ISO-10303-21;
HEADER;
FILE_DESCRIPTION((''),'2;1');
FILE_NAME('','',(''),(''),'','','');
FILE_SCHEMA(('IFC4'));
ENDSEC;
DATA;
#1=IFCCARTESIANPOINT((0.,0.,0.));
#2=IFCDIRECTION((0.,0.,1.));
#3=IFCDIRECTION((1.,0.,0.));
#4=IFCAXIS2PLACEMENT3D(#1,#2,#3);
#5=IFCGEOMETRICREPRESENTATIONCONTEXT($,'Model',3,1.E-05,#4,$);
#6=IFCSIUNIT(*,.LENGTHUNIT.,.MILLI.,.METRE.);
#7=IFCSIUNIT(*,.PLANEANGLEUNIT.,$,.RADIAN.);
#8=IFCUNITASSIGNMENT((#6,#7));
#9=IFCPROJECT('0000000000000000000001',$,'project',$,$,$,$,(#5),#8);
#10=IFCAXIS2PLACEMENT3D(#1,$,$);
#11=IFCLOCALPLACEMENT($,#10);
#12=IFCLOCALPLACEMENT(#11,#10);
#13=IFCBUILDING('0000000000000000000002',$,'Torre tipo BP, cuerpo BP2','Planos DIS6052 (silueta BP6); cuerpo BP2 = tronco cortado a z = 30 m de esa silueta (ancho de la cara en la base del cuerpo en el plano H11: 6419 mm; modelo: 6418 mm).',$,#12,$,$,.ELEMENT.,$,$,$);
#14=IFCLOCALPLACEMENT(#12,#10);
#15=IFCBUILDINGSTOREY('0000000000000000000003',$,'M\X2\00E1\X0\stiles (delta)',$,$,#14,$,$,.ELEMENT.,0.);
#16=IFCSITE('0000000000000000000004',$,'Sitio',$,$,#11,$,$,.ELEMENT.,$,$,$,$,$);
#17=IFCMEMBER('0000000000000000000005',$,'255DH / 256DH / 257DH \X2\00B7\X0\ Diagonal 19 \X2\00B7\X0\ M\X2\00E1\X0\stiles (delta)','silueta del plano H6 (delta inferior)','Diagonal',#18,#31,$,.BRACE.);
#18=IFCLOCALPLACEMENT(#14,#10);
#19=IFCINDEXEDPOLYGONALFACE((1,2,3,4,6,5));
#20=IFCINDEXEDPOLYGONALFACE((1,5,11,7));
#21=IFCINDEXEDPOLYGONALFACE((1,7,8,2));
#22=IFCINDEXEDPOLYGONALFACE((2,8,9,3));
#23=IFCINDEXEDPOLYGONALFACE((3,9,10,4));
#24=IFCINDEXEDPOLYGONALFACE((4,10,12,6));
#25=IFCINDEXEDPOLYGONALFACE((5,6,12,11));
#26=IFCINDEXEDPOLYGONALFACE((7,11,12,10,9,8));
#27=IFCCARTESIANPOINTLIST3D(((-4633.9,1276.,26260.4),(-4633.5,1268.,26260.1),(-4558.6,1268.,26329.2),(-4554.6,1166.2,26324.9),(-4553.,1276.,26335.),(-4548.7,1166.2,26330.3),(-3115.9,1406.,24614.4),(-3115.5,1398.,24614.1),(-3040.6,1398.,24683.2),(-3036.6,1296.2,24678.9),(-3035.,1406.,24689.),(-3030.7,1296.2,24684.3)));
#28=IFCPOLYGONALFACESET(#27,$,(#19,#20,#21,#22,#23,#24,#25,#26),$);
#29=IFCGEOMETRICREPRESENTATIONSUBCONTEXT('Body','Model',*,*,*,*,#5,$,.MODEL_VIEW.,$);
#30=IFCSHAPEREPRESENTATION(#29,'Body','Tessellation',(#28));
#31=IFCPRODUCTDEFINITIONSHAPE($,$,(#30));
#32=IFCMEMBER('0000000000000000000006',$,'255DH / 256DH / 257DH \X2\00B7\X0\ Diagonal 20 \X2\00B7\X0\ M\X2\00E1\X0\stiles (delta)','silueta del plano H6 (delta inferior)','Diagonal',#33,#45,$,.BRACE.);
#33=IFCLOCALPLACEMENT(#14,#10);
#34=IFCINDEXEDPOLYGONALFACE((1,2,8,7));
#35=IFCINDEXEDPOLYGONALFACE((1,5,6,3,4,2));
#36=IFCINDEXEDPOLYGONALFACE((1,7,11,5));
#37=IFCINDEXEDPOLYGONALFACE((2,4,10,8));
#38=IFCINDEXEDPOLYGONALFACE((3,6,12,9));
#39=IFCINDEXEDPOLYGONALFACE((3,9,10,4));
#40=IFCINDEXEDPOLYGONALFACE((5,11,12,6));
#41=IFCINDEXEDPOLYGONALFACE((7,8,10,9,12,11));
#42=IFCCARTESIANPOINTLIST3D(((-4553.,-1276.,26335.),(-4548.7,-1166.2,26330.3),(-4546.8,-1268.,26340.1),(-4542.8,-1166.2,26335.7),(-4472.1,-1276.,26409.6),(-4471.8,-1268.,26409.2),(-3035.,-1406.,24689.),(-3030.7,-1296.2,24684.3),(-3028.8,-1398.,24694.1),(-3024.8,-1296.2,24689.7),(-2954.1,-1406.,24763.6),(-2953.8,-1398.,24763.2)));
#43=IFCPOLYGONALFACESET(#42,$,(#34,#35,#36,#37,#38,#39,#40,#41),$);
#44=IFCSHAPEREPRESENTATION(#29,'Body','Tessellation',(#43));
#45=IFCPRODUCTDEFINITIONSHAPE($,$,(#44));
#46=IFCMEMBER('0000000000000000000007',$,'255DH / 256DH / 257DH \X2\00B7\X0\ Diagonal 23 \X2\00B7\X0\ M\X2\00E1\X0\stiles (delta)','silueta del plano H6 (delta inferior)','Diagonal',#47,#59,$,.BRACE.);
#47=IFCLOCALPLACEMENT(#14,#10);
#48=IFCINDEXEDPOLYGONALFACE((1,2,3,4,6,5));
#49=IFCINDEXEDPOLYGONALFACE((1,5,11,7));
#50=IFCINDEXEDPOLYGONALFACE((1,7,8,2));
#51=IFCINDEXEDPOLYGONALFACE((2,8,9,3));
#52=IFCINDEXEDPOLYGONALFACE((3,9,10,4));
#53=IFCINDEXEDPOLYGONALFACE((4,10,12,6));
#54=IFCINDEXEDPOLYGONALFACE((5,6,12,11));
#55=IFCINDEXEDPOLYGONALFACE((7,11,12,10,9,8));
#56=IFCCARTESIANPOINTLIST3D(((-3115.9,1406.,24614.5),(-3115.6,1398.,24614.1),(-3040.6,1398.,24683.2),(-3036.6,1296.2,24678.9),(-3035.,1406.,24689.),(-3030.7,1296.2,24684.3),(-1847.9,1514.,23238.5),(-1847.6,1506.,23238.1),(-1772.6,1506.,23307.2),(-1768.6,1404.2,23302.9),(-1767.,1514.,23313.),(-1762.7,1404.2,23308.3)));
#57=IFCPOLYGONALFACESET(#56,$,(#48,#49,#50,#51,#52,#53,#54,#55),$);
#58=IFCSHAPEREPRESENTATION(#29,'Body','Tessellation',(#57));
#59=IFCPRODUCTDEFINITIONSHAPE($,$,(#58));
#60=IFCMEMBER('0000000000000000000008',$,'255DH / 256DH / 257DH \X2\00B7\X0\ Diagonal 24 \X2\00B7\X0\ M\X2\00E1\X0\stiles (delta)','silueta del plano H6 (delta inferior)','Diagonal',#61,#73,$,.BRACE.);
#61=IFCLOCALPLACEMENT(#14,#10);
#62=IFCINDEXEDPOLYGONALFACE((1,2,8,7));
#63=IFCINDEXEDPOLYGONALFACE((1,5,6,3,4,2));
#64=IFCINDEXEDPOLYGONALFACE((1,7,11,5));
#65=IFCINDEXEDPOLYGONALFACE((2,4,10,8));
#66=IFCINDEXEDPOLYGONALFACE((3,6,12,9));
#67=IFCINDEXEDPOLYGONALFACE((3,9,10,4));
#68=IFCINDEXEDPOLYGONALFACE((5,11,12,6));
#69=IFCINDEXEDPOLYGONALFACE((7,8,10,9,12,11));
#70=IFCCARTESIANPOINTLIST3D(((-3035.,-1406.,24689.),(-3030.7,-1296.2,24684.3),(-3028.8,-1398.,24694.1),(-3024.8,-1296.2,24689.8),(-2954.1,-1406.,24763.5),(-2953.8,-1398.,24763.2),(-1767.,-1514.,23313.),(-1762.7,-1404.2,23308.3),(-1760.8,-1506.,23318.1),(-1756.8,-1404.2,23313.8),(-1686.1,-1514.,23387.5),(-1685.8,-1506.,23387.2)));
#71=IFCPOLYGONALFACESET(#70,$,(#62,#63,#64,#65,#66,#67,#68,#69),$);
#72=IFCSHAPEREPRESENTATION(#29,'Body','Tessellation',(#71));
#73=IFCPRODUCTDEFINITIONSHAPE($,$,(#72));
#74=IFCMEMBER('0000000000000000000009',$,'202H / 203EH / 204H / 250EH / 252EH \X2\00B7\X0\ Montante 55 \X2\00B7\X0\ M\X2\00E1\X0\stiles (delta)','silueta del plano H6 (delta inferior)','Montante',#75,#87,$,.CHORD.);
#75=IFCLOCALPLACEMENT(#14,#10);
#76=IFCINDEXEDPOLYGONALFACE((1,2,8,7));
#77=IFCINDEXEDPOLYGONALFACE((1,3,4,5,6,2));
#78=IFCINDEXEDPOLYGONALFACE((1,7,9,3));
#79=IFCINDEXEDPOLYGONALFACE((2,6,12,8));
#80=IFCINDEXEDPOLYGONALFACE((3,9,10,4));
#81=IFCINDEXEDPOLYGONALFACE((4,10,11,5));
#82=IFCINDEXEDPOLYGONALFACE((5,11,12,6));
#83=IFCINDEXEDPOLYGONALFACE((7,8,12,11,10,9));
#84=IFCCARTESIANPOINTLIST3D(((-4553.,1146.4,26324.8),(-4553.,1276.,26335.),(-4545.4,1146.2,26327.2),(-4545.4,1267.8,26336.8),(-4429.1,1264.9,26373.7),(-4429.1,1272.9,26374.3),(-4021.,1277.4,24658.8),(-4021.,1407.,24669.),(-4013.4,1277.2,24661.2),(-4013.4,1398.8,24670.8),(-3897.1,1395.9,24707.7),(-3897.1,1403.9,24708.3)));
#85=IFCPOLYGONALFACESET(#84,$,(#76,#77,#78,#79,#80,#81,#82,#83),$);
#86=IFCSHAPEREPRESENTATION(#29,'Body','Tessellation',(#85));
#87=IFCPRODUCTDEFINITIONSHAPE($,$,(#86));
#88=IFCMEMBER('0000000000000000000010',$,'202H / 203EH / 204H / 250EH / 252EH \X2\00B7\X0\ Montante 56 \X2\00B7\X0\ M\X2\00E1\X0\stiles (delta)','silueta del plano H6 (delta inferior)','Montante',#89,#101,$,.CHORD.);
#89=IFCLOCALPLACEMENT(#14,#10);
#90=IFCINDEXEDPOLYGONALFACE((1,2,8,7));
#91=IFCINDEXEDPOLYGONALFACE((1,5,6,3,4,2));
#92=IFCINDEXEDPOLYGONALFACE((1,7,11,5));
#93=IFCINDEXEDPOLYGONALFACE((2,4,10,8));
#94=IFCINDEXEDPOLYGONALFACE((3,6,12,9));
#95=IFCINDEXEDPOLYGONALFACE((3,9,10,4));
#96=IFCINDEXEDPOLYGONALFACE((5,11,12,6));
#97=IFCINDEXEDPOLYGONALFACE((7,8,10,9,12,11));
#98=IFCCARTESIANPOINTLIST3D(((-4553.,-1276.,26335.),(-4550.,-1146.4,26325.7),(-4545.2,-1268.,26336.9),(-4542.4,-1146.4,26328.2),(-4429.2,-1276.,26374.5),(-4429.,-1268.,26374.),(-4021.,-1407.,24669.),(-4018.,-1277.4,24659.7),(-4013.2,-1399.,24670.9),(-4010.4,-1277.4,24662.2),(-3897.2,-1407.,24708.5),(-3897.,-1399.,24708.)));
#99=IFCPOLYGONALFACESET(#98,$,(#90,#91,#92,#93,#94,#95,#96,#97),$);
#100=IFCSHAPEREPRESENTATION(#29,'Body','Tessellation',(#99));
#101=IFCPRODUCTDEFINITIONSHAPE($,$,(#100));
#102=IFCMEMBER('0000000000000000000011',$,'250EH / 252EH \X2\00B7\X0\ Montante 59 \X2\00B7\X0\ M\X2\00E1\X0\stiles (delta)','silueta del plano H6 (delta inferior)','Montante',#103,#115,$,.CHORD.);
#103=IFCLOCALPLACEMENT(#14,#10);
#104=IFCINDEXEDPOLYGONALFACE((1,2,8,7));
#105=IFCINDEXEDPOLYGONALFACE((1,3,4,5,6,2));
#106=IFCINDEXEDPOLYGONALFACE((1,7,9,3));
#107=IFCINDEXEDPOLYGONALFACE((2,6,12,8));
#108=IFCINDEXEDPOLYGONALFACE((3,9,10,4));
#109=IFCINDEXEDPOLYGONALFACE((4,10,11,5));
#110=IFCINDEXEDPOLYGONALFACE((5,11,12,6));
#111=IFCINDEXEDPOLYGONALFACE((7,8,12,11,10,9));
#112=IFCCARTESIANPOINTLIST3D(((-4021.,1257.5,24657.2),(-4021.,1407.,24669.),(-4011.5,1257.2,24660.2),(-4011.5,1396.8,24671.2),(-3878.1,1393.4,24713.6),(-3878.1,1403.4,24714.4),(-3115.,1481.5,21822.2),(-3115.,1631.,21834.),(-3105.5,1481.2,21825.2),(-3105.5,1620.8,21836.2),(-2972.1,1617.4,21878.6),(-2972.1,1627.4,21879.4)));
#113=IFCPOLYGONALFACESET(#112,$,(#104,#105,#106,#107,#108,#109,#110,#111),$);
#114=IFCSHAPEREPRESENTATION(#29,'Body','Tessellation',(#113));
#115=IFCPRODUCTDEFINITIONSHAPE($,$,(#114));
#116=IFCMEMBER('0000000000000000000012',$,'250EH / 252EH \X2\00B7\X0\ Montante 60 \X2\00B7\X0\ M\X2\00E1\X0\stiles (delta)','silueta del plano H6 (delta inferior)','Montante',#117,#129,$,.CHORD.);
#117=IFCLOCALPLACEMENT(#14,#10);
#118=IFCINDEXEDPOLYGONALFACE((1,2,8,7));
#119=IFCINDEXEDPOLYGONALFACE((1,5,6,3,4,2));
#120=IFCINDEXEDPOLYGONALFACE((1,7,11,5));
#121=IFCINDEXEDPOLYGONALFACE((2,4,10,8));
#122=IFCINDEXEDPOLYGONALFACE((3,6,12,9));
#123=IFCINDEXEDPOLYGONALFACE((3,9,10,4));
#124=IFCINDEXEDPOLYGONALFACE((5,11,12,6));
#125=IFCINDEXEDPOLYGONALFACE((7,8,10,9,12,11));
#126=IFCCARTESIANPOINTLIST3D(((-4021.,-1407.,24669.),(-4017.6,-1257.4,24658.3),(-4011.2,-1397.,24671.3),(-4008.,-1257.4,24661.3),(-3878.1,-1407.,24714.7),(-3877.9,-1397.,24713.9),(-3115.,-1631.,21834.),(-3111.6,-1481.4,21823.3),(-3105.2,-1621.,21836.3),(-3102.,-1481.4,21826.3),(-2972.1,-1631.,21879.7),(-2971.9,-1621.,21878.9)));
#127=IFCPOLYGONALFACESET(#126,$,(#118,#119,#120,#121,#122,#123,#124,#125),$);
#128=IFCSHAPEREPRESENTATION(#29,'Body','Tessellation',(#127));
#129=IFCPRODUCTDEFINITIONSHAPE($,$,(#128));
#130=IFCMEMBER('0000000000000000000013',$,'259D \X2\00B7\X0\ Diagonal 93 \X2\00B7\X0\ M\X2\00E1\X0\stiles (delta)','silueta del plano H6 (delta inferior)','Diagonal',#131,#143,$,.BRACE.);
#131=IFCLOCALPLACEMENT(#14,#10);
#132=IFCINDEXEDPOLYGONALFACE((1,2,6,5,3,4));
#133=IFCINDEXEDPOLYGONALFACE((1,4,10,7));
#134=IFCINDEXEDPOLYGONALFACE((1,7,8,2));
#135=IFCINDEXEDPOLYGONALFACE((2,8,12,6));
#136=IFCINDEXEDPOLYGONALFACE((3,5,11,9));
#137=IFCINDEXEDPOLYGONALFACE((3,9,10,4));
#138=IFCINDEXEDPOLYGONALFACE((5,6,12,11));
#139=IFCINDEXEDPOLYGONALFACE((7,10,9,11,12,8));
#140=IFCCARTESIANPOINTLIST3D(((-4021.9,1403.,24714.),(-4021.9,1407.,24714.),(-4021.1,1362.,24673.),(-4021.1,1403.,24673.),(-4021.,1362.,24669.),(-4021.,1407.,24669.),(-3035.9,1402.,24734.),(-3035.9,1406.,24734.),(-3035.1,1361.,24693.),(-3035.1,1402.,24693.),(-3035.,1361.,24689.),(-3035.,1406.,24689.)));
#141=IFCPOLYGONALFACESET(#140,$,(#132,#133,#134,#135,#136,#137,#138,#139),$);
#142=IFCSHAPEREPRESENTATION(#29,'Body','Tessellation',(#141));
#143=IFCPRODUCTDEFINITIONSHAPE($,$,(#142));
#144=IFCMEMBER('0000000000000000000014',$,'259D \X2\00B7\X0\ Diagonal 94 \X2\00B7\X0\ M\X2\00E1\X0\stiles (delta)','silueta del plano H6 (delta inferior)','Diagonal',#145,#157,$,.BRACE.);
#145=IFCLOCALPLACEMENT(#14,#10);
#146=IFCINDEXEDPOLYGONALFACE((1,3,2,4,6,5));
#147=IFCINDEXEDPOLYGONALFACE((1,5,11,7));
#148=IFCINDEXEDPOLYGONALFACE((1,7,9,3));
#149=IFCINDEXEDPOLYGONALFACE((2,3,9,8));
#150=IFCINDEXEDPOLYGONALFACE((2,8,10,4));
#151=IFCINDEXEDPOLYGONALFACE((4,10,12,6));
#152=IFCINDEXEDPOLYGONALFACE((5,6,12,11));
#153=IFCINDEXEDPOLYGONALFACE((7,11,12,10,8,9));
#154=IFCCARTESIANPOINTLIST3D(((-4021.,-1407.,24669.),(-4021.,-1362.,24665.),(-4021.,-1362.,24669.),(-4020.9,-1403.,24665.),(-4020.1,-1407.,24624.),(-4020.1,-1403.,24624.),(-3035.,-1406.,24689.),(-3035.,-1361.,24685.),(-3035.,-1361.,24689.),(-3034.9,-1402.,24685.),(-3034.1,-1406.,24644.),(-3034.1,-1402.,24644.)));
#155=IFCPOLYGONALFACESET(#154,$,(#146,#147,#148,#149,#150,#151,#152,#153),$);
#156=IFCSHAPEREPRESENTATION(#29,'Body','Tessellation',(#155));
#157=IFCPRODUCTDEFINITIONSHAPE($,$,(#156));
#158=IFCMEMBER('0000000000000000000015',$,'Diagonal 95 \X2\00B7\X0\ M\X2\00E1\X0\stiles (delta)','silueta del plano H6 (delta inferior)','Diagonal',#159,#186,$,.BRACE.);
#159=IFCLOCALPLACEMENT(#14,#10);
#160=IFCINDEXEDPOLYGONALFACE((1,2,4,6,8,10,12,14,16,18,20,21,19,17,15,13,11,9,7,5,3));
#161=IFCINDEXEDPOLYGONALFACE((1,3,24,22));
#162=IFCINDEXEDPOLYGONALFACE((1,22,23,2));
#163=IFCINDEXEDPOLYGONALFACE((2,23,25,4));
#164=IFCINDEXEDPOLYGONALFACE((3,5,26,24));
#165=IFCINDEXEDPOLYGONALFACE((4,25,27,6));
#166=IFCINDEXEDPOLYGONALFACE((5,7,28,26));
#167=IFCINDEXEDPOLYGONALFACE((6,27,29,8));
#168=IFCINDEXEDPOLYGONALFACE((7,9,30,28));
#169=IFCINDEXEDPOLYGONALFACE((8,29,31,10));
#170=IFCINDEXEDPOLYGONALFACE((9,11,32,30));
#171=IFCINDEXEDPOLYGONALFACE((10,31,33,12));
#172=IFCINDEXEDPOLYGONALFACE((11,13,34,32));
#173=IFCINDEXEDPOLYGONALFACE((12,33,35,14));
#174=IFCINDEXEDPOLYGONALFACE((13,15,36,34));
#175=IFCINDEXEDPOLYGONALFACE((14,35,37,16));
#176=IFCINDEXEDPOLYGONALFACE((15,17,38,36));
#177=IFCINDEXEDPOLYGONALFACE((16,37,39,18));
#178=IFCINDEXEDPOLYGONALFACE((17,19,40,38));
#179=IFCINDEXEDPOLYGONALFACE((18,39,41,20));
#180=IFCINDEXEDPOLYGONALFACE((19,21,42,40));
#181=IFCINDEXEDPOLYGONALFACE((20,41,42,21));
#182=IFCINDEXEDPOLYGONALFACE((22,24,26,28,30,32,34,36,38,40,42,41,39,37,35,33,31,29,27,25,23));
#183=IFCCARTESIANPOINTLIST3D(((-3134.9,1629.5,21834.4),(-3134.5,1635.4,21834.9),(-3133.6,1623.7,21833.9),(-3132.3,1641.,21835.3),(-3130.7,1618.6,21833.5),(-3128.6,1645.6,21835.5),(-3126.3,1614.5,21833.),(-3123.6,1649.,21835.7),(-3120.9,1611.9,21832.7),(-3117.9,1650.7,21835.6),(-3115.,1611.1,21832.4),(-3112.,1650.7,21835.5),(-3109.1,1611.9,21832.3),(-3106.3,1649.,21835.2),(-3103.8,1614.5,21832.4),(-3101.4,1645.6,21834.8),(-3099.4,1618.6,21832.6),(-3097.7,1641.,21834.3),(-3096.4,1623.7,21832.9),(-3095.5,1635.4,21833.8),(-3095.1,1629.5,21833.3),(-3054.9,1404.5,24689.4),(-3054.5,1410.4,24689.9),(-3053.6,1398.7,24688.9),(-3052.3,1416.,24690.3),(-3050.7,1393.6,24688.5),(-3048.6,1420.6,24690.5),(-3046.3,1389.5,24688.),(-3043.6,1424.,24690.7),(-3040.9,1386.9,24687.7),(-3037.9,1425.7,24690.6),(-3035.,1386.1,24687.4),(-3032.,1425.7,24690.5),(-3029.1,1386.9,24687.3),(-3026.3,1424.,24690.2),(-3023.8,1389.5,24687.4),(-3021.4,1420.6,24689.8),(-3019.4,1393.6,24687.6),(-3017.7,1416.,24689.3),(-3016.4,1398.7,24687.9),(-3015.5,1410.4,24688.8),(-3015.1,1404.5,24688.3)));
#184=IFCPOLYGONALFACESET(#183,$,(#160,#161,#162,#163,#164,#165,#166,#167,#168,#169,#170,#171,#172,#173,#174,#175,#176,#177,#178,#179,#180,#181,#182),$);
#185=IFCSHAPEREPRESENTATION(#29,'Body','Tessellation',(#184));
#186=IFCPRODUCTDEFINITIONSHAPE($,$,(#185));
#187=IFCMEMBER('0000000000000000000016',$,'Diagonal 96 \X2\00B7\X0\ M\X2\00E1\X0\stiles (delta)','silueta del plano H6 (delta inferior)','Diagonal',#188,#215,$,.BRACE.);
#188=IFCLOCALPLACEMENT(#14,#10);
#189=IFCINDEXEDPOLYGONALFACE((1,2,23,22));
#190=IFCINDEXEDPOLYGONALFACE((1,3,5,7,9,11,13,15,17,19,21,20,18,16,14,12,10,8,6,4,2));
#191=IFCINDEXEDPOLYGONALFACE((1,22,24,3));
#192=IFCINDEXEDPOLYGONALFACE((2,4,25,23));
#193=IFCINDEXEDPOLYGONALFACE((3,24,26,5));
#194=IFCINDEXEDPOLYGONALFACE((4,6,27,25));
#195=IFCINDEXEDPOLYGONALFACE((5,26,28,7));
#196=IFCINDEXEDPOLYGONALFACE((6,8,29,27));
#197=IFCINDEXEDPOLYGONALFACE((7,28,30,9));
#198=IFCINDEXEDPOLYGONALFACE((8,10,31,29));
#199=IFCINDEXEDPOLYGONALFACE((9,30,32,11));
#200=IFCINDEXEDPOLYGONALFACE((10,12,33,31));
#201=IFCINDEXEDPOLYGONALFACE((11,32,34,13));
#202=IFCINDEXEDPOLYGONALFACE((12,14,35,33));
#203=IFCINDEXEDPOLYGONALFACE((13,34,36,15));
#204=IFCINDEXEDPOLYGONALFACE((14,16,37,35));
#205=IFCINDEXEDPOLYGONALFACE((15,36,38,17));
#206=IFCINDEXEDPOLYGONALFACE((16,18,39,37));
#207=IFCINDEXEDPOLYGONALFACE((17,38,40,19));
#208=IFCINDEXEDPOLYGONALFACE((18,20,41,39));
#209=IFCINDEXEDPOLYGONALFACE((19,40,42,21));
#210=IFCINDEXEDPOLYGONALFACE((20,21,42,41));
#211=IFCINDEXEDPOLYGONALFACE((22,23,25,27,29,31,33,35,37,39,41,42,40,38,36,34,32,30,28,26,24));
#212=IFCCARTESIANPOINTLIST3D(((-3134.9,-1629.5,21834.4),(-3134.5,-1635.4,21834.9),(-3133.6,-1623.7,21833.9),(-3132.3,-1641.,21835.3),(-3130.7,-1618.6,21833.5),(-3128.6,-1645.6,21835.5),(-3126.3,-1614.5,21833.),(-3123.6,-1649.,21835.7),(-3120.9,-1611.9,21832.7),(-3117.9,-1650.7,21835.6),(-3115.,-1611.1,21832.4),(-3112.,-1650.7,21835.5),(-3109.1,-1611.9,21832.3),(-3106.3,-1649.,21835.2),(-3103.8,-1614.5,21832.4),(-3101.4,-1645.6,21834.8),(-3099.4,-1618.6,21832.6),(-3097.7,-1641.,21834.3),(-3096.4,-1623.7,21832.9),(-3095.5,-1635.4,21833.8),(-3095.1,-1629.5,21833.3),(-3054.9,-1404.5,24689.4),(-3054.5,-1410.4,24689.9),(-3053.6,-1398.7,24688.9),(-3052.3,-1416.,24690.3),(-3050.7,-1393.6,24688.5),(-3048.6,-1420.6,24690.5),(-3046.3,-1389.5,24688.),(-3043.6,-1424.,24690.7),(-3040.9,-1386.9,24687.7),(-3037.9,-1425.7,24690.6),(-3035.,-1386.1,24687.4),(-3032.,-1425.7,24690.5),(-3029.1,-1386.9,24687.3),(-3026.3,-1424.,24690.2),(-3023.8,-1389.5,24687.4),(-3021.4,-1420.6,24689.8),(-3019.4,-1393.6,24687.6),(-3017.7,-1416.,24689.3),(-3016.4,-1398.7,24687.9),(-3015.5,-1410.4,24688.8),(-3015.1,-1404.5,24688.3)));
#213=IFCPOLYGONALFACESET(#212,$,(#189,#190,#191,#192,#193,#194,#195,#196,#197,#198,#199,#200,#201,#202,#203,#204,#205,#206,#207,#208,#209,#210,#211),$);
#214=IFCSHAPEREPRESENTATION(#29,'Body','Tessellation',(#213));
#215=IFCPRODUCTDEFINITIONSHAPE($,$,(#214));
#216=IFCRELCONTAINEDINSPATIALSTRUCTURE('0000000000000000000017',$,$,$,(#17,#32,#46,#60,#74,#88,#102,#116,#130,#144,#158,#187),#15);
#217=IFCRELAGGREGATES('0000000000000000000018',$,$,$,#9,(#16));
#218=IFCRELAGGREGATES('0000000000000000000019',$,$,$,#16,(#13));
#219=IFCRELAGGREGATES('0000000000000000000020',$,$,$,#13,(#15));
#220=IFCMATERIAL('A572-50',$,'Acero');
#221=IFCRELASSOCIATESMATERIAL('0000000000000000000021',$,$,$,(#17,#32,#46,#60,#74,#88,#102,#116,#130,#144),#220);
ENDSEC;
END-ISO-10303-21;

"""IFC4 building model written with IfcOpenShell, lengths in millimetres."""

from ifc_helpers import new_model, si_unit, frame, frame_2d, origin, origin_with_axes, place, context, subcontext, project, spatial, circle, l_section, extrude, material, element, save


model = new_model("IFC4")

# Units and contexts
model_context = context("Model", 3, precision=1e-05, world=origin_with_axes())
body_context = subcontext(model_context, "Body", "Model", "MODEL_VIEW")
ifc_project = project(units=[si_unit("LENGTHUNIT", "METRE", prefix="MILLI"), si_unit("PLANEANGLEUNIT", "RADIAN")], contexts=[model_context])

# Site, building, storey
site_placement = place(None, origin())
site = spatial("IfcSite", under=ifc_project, at=site_placement, Name="Sitio", CompositionType="ELEMENT")
building_placement = place(site_placement, origin())
building = spatial("IfcBuilding", under=site, at=building_placement, Name="Torre tipo BP, cuerpo BP2", Description="Planos DIS6052 (silueta BP6); cuerpo BP2 = tronco cortado a z = 30 m de esa silueta (ancho de la cara en la base del cuerpo en el plano H11: 6419 mm; modelo: 6418 mm).", CompositionType="ELEMENT")
storey_placement = place(building_placement, origin())
storey = spatial("IfcBuildingStorey", under=building, at=storey_placement, Name="Mástiles (delta)", CompositionType="ELEMENT", Elevation=0.0)

# Members
ifc_material = material(Name="A572-50", Category="Acero")
for number, where, z_axis, x_axis, name in (
    (1, (-4553.0, 1276.0, 26335.0), (0.676806, 0.057961, -0.733876), (0.039294, -0.998319, -0.042608), "255DH / 256DH / 257DH · Diagonal 19 · Mástiles (delta)"),
    (2, (-4553.0, -1276.0, 26335.0), (0.676806, -0.057961, -0.733876), (0.039294, 0.998319, -0.042608), "255DH / 256DH / 257DH · Diagonal 20 · Mástiles (delta)"),
):
    element("IfcMember", number, at=place(storey_placement, frame(where, z_axis=z_axis, x_axis=x_axis)), inside=storey, material=ifc_material, Name=name, Description="silueta del plano H6 (delta inferior)", ObjectType="Diagonal", PredefinedType="BRACE", context=body_context, shape_type="SweptSolid", body=[
        extrude(l_section(Depth=110.0, Width=110.0, Thickness=8.0, at=frame_2d((55.0, 55.0))), None, (0.0, 0.0, 1.0), 2242.9),
    ])
for number, where, z_axis, x_axis, name in (
    (3, (-3035.0, 1406.0, 24689.0), (0.676532, 0.057623, -0.734155), (0.039048, -0.998338, -0.042374), "255DH / 256DH / 257DH · Diagonal 23 · Mástiles (delta)"),
    (4, (-3035.0, -1406.0, 24689.0), (0.676532, -0.057623, -0.734155), (0.039048, 0.998338, -0.042374), "255DH / 256DH / 257DH · Diagonal 24 · Mástiles (delta)"),
):
    element("IfcMember", number, at=place(storey_placement, frame(where, z_axis=z_axis, x_axis=x_axis)), inside=storey, material=ifc_material, Name=name, Description="silueta del plano H6 (delta inferior)", ObjectType="Diagonal", PredefinedType="BRACE", context=body_context, shape_type="SweptSolid", body=[
        extrude(l_section(Depth=110.0, Width=110.0, Thickness=8.0, at=frame_2d((55.0, 55.0))), None, (0.0, 0.0, 1.0), 1874.3),
    ])
for number, where, z_axis, x_axis, name in (
    (5, (-4553.0, 1276.0, 26335.0), (0.303345, 0.074696, -0.949949), (0.952881, -0.023779, 0.302411), "202H / 203EH / 204H / 250EH / 252EH · Montante 55 · Mástiles (delta)"),
    (6, (-4553.0, -1276.0, 26335.0), (0.303345, -0.074696, -0.949949), (0.022722, 0.997206, -0.071156), "202H / 203EH / 204H / 250EH / 252EH · Montante 56 · Mástiles (delta)"),
):
    element("IfcMember", number, at=place(storey_placement, frame(where, z_axis=z_axis, x_axis=x_axis)), inside=storey, material=ifc_material, Name=name, Description="silueta del plano H6 (delta inferior)", ObjectType="Montante", PredefinedType="CHORD", context=body_context, shape_type="SweptSolid", body=[
        extrude(l_section(Depth=130.0, Width=130.0, Thickness=8.0, at=frame_2d((65.0, 65.0))), None, (0.0, 0.0, 1.0), 1753.8),
    ])
for number, where, z_axis, x_axis, name in (
    (7, (-4021.0, 1407.0, 24669.0), (0.303551, 0.07505, -0.949855), (0.952815, -0.02391, 0.302608), "250EH / 252EH · Montante 59 · Mástiles (delta)"),
    (8, (-4021.0, -1407.0, 24669.0), (0.303551, -0.07505, -0.949855), (0.022846, 0.99718, -0.071488), "250EH / 252EH · Montante 60 · Mástiles (delta)"),
):
    element("IfcMember", number, at=place(storey_placement, frame(where, z_axis=z_axis, x_axis=x_axis)), inside=storey, material=ifc_material, Name=name, Description="silueta del plano H6 (delta inferior)", ObjectType="Montante", PredefinedType="CHORD", context=body_context, shape_type="SweptSolid", body=[
        extrude(l_section(Depth=150.0, Width=150.0, Thickness=10.0, at=frame_2d((75.0, 75.0))), None, (0.0, 0.0, 1.0), 2984.7),
    ])
for number, where, z_axis, x_axis, name in (
    (9, (-3035.0, 1406.0, 24689.0), (-0.999794, 0.001014, -0.02028), (-0.001014, -0.999999, -0.000021), "259D · Diagonal 93 · Mástiles (delta)"),
    (10, (-3035.0, -1406.0, 24689.0), (-0.999794, -0.001014, -0.02028), (-0.001014, 0.999999, -0.000021), "259D · Diagonal 94 · Mástiles (delta)"),
):
    element("IfcMember", number, at=place(storey_placement, frame(where, z_axis=z_axis, x_axis=x_axis)), inside=storey, material=ifc_material, Name=name, Description="silueta del plano H6 (delta inferior)", ObjectType="Diagonal", PredefinedType="BRACE", context=body_context, shape_type="SweptSolid", body=[
        extrude(l_section(Depth=45.0, Width=45.0, Thickness=4.0, at=frame_2d((22.5, 22.5))), None, (0.0, 0.0, 1.0), 986.2),
    ])
for number, where, z_axis, x_axis, name in (
    (11, (-3035.0, 1406.0, 24689.0), (-0.027924, 0.078535, -0.99652), (-0.0022, -0.996911, -0.078504), "Diagonal 95 · Mástiles (delta)"),
    (12, (-3035.0, -1406.0, 24689.0), (-0.027924, -0.078535, -0.99652), (-0.0022, 0.996911, -0.078504), "Diagonal 96 · Mástiles (delta)"),
):
    element("IfcMember", number, at=place(storey_placement, frame(where, z_axis=z_axis, x_axis=x_axis)), inside=storey, Name=name, Description="silueta del plano H6 (delta inferior)", ObjectType="Diagonal", PredefinedType="BRACE", context=body_context, shape_type="SweptSolid", body=[
        extrude(circle(Radius=20.0), None, (0.0, 0.0, 1.0), 2865.0),
    ])

save(model, "model.ifc")
